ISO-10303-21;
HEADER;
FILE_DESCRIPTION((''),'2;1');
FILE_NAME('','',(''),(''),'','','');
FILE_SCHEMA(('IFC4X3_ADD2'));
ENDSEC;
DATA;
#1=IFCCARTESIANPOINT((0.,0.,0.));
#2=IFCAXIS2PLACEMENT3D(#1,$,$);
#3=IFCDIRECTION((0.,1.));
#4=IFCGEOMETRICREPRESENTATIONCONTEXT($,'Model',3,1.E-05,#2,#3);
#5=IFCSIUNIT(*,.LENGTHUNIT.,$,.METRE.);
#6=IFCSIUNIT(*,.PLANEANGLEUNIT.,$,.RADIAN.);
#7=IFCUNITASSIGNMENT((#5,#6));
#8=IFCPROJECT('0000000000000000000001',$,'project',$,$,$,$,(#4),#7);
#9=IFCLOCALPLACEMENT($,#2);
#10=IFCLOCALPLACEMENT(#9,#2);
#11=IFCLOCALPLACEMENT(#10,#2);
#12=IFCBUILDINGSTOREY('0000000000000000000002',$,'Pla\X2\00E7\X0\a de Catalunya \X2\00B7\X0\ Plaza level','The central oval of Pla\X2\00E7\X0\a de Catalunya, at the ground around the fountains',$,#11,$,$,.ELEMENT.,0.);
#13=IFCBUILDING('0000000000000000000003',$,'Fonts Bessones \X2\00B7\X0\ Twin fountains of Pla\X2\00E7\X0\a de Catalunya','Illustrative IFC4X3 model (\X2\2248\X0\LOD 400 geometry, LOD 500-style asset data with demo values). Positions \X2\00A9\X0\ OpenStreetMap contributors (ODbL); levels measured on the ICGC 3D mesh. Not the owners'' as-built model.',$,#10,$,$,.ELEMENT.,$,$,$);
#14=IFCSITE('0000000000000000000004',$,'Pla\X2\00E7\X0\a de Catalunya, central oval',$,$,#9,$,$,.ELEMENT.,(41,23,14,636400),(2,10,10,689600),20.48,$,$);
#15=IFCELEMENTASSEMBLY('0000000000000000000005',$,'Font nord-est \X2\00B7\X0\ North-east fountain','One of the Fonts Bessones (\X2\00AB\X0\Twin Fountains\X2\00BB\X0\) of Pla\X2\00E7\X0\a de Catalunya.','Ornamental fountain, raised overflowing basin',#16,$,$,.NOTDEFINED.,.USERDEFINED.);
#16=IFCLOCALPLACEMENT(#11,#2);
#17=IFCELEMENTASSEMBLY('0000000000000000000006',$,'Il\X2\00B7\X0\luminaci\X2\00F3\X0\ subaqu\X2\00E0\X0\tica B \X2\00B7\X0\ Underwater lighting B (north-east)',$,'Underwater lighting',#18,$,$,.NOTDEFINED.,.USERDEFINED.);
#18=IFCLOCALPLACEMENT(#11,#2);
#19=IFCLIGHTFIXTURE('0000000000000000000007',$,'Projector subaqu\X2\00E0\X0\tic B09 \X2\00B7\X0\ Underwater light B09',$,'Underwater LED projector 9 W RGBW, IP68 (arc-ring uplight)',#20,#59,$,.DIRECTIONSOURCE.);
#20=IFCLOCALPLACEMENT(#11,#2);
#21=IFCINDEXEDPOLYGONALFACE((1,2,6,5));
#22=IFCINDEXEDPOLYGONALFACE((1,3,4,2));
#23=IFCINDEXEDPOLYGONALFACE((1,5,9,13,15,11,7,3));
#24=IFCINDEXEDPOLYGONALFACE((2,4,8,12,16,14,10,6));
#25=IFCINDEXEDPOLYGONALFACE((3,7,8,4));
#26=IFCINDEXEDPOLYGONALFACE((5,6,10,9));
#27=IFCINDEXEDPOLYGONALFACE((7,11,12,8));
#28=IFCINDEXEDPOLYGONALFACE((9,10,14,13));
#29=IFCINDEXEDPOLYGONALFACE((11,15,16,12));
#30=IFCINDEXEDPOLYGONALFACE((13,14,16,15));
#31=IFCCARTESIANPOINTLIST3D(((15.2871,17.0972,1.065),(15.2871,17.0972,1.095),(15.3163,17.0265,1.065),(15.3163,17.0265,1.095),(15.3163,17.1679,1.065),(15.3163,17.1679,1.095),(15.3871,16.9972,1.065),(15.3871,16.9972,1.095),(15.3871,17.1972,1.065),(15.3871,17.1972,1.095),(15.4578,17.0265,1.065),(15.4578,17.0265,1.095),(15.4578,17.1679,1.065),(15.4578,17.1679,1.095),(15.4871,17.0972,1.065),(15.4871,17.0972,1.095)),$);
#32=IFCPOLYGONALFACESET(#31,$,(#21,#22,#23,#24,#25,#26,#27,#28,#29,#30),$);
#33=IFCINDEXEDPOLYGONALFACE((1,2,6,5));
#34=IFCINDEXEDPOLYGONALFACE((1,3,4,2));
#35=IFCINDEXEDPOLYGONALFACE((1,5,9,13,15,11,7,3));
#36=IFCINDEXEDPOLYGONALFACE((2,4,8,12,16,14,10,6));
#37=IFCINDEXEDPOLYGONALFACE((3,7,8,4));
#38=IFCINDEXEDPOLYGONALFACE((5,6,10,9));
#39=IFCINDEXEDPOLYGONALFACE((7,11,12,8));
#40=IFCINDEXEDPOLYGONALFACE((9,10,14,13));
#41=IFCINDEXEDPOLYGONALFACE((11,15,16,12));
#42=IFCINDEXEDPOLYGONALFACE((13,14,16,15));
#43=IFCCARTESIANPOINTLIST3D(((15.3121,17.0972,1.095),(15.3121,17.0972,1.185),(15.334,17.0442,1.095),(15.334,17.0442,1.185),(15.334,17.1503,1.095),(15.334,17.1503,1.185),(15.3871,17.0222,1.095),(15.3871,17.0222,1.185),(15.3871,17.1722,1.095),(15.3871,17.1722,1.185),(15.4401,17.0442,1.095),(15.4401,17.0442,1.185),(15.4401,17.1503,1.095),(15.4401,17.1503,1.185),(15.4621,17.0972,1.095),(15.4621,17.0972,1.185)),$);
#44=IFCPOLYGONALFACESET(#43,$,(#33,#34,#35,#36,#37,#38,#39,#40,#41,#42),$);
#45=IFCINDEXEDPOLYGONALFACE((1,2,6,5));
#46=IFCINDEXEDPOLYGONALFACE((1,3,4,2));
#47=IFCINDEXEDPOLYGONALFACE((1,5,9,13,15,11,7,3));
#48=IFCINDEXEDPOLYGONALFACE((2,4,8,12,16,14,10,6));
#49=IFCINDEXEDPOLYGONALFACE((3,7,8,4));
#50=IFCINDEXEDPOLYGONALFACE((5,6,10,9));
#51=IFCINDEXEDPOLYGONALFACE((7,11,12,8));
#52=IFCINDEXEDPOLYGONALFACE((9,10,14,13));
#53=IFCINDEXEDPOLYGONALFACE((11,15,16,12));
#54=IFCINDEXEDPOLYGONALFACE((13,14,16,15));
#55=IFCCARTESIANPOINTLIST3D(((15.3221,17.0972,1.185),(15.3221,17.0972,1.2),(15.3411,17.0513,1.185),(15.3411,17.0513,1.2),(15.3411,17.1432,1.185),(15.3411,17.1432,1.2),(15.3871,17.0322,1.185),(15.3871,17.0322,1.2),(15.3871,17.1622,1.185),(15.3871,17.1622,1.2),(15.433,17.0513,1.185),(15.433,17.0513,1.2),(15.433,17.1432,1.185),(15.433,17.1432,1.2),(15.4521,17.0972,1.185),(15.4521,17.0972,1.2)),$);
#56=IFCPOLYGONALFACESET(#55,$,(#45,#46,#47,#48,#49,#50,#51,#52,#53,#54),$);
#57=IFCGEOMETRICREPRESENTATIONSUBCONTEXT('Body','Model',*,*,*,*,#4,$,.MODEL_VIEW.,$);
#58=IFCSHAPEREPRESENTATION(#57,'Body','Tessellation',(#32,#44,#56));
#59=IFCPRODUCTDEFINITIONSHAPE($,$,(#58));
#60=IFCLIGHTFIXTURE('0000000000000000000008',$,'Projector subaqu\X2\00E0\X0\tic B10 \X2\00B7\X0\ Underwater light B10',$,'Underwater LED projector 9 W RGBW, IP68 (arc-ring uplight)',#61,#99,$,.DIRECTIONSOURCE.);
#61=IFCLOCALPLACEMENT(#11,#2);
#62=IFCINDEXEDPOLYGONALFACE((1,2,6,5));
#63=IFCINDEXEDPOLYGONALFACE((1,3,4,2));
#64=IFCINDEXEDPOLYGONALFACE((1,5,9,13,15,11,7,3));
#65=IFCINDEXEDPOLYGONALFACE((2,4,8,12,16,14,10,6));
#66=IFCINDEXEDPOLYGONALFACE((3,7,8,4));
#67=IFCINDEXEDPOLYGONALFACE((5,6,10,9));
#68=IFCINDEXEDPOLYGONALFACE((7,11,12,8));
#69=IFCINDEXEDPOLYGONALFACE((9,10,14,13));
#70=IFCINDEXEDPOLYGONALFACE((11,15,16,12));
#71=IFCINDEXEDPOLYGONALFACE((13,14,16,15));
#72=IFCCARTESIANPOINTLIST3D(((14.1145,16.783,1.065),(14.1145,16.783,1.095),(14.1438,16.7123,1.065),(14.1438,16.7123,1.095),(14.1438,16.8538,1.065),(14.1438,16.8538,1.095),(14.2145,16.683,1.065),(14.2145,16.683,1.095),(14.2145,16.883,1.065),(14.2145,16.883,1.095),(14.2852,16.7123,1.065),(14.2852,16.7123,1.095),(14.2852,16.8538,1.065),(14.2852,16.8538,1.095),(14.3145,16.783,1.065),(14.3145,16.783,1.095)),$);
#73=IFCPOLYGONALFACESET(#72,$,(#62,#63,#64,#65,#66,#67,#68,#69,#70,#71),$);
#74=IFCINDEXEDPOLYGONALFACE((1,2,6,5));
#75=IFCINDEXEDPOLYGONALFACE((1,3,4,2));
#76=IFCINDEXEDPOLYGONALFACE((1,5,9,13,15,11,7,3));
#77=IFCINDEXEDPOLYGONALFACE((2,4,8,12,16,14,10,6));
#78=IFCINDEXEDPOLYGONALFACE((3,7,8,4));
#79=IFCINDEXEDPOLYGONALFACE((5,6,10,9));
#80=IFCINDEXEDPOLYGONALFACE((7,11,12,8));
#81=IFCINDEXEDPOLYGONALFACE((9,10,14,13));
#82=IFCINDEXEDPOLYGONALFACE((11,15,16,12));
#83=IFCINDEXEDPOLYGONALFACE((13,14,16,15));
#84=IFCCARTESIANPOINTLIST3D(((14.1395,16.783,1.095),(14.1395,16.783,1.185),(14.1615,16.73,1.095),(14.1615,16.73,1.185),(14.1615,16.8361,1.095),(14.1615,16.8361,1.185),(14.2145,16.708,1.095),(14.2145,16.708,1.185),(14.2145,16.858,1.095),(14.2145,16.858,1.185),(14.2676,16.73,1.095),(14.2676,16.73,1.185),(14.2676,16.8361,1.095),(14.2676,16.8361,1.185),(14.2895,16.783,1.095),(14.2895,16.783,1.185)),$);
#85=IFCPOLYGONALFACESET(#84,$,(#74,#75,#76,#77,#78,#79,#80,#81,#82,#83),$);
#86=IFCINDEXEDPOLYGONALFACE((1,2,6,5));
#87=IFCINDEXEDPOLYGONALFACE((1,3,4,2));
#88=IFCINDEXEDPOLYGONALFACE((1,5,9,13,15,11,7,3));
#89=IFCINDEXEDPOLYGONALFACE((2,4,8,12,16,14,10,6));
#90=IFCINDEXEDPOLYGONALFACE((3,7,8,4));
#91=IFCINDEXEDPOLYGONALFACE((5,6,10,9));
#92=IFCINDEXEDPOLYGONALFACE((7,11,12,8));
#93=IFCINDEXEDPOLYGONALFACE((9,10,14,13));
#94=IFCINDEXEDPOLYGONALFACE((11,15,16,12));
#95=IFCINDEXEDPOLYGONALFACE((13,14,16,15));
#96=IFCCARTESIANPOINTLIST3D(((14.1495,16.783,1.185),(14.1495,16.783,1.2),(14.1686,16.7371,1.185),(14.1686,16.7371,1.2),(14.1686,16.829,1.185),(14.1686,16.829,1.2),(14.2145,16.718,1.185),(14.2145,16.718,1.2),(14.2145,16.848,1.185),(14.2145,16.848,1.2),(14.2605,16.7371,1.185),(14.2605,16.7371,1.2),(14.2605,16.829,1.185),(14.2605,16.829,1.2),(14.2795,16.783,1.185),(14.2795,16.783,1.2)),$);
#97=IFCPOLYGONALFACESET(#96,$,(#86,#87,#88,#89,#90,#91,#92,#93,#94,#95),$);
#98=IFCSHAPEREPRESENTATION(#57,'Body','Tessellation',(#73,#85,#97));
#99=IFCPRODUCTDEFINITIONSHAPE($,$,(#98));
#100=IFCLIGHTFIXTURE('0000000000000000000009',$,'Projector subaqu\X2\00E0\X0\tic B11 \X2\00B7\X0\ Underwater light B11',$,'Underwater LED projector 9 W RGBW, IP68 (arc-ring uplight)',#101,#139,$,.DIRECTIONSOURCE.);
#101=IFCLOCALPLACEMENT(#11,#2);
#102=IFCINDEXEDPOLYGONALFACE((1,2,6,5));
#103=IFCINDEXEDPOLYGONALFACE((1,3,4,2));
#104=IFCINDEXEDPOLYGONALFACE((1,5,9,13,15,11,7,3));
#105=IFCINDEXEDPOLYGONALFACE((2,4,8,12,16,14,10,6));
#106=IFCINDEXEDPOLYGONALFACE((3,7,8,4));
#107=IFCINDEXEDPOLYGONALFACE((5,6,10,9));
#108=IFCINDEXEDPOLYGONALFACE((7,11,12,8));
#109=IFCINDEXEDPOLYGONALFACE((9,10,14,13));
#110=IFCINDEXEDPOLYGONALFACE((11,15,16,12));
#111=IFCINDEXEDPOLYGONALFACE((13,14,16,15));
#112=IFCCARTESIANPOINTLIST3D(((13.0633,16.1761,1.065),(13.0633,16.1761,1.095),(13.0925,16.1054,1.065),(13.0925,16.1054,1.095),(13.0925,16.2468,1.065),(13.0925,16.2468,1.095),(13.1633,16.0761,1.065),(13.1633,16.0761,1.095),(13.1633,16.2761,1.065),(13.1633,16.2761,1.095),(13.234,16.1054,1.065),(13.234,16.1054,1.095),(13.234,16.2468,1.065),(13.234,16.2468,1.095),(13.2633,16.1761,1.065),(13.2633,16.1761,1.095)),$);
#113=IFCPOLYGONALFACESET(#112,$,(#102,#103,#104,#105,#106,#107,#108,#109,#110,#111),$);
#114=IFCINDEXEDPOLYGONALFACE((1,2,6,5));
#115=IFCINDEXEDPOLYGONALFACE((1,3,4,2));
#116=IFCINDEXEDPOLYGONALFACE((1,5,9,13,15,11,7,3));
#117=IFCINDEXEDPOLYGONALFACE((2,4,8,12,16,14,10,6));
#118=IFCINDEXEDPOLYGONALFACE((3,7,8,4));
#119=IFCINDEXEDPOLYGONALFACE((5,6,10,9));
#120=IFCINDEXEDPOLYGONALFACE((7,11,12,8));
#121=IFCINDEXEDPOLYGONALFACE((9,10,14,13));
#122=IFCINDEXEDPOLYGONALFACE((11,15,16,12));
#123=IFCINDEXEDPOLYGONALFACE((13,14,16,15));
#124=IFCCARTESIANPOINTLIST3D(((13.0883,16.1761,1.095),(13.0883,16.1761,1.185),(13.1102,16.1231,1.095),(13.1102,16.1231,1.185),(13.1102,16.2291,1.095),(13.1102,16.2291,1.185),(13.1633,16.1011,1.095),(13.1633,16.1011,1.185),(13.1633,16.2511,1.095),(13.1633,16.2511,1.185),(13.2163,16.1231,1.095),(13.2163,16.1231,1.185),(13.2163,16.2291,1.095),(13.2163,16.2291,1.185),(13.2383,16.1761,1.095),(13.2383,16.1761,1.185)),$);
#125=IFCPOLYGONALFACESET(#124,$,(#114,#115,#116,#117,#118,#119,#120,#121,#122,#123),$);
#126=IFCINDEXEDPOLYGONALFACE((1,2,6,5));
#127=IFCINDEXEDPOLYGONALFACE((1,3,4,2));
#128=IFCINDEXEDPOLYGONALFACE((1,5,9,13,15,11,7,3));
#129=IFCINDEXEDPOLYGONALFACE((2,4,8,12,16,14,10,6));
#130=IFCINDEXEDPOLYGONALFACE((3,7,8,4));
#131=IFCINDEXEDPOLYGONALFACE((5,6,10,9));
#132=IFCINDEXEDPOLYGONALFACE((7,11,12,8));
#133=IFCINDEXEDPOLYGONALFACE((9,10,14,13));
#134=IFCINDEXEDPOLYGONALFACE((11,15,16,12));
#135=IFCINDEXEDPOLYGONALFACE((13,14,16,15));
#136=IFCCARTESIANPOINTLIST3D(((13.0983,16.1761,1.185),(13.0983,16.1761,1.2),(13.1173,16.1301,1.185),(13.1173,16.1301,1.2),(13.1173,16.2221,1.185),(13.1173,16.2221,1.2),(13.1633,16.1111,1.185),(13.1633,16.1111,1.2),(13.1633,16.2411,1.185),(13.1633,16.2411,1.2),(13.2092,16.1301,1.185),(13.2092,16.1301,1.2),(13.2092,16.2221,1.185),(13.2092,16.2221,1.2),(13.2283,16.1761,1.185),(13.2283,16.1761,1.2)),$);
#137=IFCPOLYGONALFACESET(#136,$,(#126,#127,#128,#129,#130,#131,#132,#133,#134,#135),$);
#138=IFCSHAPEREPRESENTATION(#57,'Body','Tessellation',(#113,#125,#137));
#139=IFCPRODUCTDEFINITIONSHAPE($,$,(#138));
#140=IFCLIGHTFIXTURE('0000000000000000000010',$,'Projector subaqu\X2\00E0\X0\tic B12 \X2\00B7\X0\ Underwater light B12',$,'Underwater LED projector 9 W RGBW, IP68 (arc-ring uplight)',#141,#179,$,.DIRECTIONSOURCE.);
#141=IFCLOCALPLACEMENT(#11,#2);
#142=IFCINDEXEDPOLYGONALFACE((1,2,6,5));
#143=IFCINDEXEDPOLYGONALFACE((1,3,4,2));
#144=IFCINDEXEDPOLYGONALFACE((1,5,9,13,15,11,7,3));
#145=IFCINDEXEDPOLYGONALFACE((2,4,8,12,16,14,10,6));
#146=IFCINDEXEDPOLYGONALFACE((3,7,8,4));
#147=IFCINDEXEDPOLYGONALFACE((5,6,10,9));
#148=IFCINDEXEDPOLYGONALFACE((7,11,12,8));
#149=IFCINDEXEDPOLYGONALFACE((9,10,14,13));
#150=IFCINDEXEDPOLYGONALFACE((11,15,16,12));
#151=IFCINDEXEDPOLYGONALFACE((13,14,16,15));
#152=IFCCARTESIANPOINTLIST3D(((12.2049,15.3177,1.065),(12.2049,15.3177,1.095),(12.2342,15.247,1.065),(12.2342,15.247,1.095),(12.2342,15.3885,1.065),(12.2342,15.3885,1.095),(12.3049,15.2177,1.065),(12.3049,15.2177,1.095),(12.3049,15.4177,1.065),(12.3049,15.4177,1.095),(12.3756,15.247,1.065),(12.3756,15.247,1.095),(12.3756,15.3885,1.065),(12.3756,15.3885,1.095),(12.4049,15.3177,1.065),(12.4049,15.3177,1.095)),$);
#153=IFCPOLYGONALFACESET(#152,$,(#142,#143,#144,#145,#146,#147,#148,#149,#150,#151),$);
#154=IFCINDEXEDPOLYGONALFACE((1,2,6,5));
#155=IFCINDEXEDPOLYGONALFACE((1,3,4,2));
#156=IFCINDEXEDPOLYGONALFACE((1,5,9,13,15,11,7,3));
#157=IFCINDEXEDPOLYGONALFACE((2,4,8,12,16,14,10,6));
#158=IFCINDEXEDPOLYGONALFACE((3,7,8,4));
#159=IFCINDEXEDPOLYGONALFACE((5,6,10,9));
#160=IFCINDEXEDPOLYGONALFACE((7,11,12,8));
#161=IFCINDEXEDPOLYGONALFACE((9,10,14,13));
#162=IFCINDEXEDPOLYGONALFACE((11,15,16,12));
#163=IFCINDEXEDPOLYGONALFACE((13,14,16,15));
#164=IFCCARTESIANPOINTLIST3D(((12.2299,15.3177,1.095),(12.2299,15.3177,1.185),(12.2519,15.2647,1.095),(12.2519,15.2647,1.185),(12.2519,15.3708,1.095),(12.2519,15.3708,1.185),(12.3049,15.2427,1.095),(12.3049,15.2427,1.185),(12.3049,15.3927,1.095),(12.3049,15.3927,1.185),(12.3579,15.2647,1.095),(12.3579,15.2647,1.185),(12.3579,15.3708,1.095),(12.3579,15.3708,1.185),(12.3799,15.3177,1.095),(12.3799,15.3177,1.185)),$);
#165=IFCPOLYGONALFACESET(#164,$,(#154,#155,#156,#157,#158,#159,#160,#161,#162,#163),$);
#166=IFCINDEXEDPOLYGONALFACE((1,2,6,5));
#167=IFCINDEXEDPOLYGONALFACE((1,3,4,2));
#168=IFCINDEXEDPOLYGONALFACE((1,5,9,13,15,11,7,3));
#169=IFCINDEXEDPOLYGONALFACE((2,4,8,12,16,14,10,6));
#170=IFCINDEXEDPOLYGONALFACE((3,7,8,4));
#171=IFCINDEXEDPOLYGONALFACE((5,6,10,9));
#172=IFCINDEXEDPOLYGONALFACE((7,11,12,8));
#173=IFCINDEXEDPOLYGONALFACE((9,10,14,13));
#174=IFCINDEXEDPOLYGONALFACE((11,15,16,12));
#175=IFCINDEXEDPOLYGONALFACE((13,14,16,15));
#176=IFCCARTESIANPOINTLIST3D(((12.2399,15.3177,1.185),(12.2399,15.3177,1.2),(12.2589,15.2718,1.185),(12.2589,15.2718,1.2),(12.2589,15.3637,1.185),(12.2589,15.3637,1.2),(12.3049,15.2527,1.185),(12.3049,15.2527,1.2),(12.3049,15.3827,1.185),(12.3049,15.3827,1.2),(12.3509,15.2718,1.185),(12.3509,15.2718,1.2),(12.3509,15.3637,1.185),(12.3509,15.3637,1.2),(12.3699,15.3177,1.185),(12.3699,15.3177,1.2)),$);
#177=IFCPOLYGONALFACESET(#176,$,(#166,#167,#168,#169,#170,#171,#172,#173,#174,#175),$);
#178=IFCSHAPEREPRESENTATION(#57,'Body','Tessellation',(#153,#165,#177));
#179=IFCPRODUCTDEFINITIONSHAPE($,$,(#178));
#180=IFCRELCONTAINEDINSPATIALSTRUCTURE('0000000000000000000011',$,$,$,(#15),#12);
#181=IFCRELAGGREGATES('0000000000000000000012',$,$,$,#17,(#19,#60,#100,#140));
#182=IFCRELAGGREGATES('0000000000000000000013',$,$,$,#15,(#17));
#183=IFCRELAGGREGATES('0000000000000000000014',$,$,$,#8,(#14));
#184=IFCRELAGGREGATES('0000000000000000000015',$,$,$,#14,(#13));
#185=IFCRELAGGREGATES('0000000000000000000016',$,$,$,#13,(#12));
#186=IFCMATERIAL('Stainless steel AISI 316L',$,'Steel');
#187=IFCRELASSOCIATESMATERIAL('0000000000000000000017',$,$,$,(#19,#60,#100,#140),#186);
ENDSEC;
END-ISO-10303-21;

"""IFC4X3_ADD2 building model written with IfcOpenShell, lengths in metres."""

from ifc_helpers import new_model, si_unit, direction, frame, origin, place, context, subcontext, project, spatial, polyline, outline, extrude, material, element, aggregate, save


model = new_model("IFC4X3_ADD2")

# Units and contexts
model_context = context("Model", 3, precision=1e-05, world=origin(), true_north=direction((0.0, 1.0)))
body_context = subcontext(model_context, "Body", "Model", "MODEL_VIEW")
ifc_project = project(units=[si_unit("LENGTHUNIT", "METRE"), si_unit("PLANEANGLEUNIT", "RADIAN")], contexts=[model_context])

# Site, building, storey
site_placement = place(None, origin())
site = spatial("IfcSite", under=ifc_project, at=site_placement, Name="Plaça de Catalunya, central oval", CompositionType="ELEMENT", RefLatitude=(41, 23, 14, 636400), RefLongitude=(2, 10, 10, 689600), RefElevation=20.48)
building_placement = place(site_placement, origin())
building = spatial("IfcBuilding", under=site, at=building_placement, Name="Fonts Bessones · Twin fountains of Plaça de Catalunya", Description="Illustrative IFC4X3 model (≈LOD 400 geometry, LOD 500-style asset data with demo values). Positions © OpenStreetMap contributors (ODbL); levels measured on the ICGC 3D mesh. Not the owners' as-built model.", CompositionType="ELEMENT")
storey_placement = place(building_placement, origin())
storey = spatial("IfcBuildingStorey", under=building, at=storey_placement, Name="Plaça de Catalunya · Plaza level", Description="The central oval of Plaça de Catalunya, at the ground around the fountains", CompositionType="ELEMENT", Elevation=0.0)

# Element assemblies, light fixtures
assembly_1_placement = place(building_placement, origin())
assembly_1 = element("IfcElementAssembly", 1, at=assembly_1_placement, inside=storey, Name="Font nord-est · North-east fountain", Description="One of the Fonts Bessones («Twin Fountains») of Plaça de Catalunya.", ObjectType="Ornamental fountain, raised overflowing basin", AssemblyPlace="NOTDEFINED", PredefinedType="USERDEFINED")
assembly_2_placement = place(building_placement, origin())
assembly_2 = element("IfcElementAssembly", 2, at=assembly_2_placement, Name="Il·luminació subaquàtica B · Underwater lighting B (north-east)", ObjectType="Underwater lighting", AssemblyPlace="NOTDEFINED", PredefinedType="USERDEFINED")
ifc_material_1 = material(Name="Stainless steel AISI 316L", Category="Steel")
light_fixture_1_placement = place(building_placement, origin())
light_fixture_1 = element("IfcLightFixture", 3, at=light_fixture_1_placement, material=ifc_material_1, Name="Projector subaquàtic B09 · Underwater light B09", ObjectType="Underwater LED projector 9 W RGBW, IP68 (arc-ring uplight)", PredefinedType="DIRECTIONSOURCE", context=body_context, shape_type="SweptSolid", body=[
    extrude(outline(polyline([(15.4871, 17.0972), (15.4578, 17.1679), (15.3871, 17.1972), (15.3163, 17.1679), (15.2871, 17.0972), (15.3163, 17.0265), (15.3871, 16.9972), (15.4578, 17.0265), (15.4871, 17.0972)])), frame((0.0, 0.0, 1.065)), (0.0, 0.0, 1.0), 0.03),
    extrude(outline(polyline([(15.4621, 17.0972), (15.4401, 17.1503), (15.3871, 17.1722), (15.334, 17.1503), (15.3121, 17.0972), (15.334, 17.0442), (15.3871, 17.0222), (15.4401, 17.0442), (15.4621, 17.0972)])), frame((0.0, 0.0, 1.095)), (0.0, 0.0, 1.0), 0.09),
    extrude(outline(polyline([(15.4521, 17.0972), (15.433, 17.1432), (15.3871, 17.1622), (15.3411, 17.1432), (15.3221, 17.0972), (15.3411, 17.0513), (15.3871, 17.0322), (15.433, 17.0513), (15.4521, 17.0972)])), frame((0.0, 0.0, 1.185)), (0.0, 0.0, 1.0), 0.015),
])
light_fixture_2_placement = place(building_placement, origin())
light_fixture_2 = element("IfcLightFixture", 4, at=light_fixture_2_placement, material=ifc_material_1, Name="Projector subaquàtic B10 · Underwater light B10", ObjectType="Underwater LED projector 9 W RGBW, IP68 (arc-ring uplight)", PredefinedType="DIRECTIONSOURCE", context=body_context, shape_type="SweptSolid", body=[
    extrude(outline(polyline([(14.3145, 16.783), (14.2852, 16.8538), (14.2145, 16.883), (14.1438, 16.8538), (14.1145, 16.783), (14.1438, 16.7123), (14.2145, 16.683), (14.2852, 16.7123), (14.3145, 16.783)])), frame((0.0, 0.0, 1.065)), (0.0, 0.0, 1.0), 0.03),
    extrude(outline(polyline([(14.2895, 16.783), (14.2676, 16.8361), (14.2145, 16.858), (14.1615, 16.8361), (14.1395, 16.783), (14.1615, 16.73), (14.2145, 16.708), (14.2676, 16.73), (14.2895, 16.783)])), frame((0.0, 0.0, 1.095)), (0.0, 0.0, 1.0), 0.09),
    extrude(outline(polyline([(14.2795, 16.783), (14.2605, 16.829), (14.2145, 16.848), (14.1686, 16.829), (14.1495, 16.783), (14.1686, 16.7371), (14.2145, 16.718), (14.2605, 16.7371), (14.2795, 16.783)])), frame((0.0, 0.0, 1.185)), (0.0, 0.0, 1.0), 0.015),
])
light_fixture_3_placement = place(building_placement, origin())
light_fixture_3 = element("IfcLightFixture", 5, at=light_fixture_3_placement, material=ifc_material_1, Name="Projector subaquàtic B11 · Underwater light B11", ObjectType="Underwater LED projector 9 W RGBW, IP68 (arc-ring uplight)", PredefinedType="DIRECTIONSOURCE", context=body_context, shape_type="SweptSolid", body=[
    extrude(outline(polyline([(13.2633, 16.1761), (13.234, 16.2468), (13.1633, 16.2761), (13.0925, 16.2468), (13.0633, 16.1761), (13.0925, 16.1054), (13.1633, 16.0761), (13.234, 16.1054), (13.2633, 16.1761)])), frame((0.0, 0.0, 1.065)), (0.0, 0.0, 1.0), 0.03),
    extrude(outline(polyline([(13.2383, 16.1761), (13.2163, 16.2291), (13.1633, 16.2511), (13.1102, 16.2291), (13.0883, 16.1761), (13.1102, 16.1231), (13.1633, 16.1011), (13.2163, 16.1231), (13.2383, 16.1761)])), frame((0.0, 0.0, 1.095)), (0.0, 0.0, 1.0), 0.09),
    extrude(outline(polyline([(13.2283, 16.1761), (13.2092, 16.2221), (13.1633, 16.2411), (13.1173, 16.2221), (13.0983, 16.1761), (13.1173, 16.1301), (13.1633, 16.1111), (13.2092, 16.1301), (13.2283, 16.1761)])), frame((0.0, 0.0, 1.185)), (0.0, 0.0, 1.0), 0.015),
])
light_fixture_4_placement = place(building_placement, origin())
light_fixture_4 = element("IfcLightFixture", 6, at=light_fixture_4_placement, material=ifc_material_1, Name="Projector subaquàtic B12 · Underwater light B12", ObjectType="Underwater LED projector 9 W RGBW, IP68 (arc-ring uplight)", PredefinedType="DIRECTIONSOURCE", context=body_context, shape_type="SweptSolid", body=[
    extrude(outline(polyline([(12.4049, 15.3177), (12.3756, 15.3885), (12.3049, 15.4177), (12.2342, 15.3885), (12.2049, 15.3177), (12.2342, 15.247), (12.3049, 15.2177), (12.3756, 15.247), (12.4049, 15.3177)])), frame((0.0, 0.0, 1.065)), (0.0, 0.0, 1.0), 0.03),
    extrude(outline(polyline([(12.3799, 15.3177), (12.3579, 15.3708), (12.3049, 15.3927), (12.2519, 15.3708), (12.2299, 15.3177), (12.2519, 15.2647), (12.3049, 15.2427), (12.3579, 15.2647), (12.3799, 15.3177)])), frame((0.0, 0.0, 1.095)), (0.0, 0.0, 1.0), 0.09),
    extrude(outline(polyline([(12.3699, 15.3177), (12.3509, 15.3637), (12.3049, 15.3827), (12.2589, 15.3637), (12.2399, 15.3177), (12.2589, 15.2718), (12.3049, 15.2527), (12.3509, 15.2718), (12.3699, 15.3177)])), frame((0.0, 0.0, 1.185)), (0.0, 0.0, 1.0), 0.015),
])
aggregate(assembly_2, [light_fixture_1, light_fixture_2, light_fixture_3, light_fixture_4])
aggregate(assembly_1, [assembly_2])

save(model, "model.ifc")
